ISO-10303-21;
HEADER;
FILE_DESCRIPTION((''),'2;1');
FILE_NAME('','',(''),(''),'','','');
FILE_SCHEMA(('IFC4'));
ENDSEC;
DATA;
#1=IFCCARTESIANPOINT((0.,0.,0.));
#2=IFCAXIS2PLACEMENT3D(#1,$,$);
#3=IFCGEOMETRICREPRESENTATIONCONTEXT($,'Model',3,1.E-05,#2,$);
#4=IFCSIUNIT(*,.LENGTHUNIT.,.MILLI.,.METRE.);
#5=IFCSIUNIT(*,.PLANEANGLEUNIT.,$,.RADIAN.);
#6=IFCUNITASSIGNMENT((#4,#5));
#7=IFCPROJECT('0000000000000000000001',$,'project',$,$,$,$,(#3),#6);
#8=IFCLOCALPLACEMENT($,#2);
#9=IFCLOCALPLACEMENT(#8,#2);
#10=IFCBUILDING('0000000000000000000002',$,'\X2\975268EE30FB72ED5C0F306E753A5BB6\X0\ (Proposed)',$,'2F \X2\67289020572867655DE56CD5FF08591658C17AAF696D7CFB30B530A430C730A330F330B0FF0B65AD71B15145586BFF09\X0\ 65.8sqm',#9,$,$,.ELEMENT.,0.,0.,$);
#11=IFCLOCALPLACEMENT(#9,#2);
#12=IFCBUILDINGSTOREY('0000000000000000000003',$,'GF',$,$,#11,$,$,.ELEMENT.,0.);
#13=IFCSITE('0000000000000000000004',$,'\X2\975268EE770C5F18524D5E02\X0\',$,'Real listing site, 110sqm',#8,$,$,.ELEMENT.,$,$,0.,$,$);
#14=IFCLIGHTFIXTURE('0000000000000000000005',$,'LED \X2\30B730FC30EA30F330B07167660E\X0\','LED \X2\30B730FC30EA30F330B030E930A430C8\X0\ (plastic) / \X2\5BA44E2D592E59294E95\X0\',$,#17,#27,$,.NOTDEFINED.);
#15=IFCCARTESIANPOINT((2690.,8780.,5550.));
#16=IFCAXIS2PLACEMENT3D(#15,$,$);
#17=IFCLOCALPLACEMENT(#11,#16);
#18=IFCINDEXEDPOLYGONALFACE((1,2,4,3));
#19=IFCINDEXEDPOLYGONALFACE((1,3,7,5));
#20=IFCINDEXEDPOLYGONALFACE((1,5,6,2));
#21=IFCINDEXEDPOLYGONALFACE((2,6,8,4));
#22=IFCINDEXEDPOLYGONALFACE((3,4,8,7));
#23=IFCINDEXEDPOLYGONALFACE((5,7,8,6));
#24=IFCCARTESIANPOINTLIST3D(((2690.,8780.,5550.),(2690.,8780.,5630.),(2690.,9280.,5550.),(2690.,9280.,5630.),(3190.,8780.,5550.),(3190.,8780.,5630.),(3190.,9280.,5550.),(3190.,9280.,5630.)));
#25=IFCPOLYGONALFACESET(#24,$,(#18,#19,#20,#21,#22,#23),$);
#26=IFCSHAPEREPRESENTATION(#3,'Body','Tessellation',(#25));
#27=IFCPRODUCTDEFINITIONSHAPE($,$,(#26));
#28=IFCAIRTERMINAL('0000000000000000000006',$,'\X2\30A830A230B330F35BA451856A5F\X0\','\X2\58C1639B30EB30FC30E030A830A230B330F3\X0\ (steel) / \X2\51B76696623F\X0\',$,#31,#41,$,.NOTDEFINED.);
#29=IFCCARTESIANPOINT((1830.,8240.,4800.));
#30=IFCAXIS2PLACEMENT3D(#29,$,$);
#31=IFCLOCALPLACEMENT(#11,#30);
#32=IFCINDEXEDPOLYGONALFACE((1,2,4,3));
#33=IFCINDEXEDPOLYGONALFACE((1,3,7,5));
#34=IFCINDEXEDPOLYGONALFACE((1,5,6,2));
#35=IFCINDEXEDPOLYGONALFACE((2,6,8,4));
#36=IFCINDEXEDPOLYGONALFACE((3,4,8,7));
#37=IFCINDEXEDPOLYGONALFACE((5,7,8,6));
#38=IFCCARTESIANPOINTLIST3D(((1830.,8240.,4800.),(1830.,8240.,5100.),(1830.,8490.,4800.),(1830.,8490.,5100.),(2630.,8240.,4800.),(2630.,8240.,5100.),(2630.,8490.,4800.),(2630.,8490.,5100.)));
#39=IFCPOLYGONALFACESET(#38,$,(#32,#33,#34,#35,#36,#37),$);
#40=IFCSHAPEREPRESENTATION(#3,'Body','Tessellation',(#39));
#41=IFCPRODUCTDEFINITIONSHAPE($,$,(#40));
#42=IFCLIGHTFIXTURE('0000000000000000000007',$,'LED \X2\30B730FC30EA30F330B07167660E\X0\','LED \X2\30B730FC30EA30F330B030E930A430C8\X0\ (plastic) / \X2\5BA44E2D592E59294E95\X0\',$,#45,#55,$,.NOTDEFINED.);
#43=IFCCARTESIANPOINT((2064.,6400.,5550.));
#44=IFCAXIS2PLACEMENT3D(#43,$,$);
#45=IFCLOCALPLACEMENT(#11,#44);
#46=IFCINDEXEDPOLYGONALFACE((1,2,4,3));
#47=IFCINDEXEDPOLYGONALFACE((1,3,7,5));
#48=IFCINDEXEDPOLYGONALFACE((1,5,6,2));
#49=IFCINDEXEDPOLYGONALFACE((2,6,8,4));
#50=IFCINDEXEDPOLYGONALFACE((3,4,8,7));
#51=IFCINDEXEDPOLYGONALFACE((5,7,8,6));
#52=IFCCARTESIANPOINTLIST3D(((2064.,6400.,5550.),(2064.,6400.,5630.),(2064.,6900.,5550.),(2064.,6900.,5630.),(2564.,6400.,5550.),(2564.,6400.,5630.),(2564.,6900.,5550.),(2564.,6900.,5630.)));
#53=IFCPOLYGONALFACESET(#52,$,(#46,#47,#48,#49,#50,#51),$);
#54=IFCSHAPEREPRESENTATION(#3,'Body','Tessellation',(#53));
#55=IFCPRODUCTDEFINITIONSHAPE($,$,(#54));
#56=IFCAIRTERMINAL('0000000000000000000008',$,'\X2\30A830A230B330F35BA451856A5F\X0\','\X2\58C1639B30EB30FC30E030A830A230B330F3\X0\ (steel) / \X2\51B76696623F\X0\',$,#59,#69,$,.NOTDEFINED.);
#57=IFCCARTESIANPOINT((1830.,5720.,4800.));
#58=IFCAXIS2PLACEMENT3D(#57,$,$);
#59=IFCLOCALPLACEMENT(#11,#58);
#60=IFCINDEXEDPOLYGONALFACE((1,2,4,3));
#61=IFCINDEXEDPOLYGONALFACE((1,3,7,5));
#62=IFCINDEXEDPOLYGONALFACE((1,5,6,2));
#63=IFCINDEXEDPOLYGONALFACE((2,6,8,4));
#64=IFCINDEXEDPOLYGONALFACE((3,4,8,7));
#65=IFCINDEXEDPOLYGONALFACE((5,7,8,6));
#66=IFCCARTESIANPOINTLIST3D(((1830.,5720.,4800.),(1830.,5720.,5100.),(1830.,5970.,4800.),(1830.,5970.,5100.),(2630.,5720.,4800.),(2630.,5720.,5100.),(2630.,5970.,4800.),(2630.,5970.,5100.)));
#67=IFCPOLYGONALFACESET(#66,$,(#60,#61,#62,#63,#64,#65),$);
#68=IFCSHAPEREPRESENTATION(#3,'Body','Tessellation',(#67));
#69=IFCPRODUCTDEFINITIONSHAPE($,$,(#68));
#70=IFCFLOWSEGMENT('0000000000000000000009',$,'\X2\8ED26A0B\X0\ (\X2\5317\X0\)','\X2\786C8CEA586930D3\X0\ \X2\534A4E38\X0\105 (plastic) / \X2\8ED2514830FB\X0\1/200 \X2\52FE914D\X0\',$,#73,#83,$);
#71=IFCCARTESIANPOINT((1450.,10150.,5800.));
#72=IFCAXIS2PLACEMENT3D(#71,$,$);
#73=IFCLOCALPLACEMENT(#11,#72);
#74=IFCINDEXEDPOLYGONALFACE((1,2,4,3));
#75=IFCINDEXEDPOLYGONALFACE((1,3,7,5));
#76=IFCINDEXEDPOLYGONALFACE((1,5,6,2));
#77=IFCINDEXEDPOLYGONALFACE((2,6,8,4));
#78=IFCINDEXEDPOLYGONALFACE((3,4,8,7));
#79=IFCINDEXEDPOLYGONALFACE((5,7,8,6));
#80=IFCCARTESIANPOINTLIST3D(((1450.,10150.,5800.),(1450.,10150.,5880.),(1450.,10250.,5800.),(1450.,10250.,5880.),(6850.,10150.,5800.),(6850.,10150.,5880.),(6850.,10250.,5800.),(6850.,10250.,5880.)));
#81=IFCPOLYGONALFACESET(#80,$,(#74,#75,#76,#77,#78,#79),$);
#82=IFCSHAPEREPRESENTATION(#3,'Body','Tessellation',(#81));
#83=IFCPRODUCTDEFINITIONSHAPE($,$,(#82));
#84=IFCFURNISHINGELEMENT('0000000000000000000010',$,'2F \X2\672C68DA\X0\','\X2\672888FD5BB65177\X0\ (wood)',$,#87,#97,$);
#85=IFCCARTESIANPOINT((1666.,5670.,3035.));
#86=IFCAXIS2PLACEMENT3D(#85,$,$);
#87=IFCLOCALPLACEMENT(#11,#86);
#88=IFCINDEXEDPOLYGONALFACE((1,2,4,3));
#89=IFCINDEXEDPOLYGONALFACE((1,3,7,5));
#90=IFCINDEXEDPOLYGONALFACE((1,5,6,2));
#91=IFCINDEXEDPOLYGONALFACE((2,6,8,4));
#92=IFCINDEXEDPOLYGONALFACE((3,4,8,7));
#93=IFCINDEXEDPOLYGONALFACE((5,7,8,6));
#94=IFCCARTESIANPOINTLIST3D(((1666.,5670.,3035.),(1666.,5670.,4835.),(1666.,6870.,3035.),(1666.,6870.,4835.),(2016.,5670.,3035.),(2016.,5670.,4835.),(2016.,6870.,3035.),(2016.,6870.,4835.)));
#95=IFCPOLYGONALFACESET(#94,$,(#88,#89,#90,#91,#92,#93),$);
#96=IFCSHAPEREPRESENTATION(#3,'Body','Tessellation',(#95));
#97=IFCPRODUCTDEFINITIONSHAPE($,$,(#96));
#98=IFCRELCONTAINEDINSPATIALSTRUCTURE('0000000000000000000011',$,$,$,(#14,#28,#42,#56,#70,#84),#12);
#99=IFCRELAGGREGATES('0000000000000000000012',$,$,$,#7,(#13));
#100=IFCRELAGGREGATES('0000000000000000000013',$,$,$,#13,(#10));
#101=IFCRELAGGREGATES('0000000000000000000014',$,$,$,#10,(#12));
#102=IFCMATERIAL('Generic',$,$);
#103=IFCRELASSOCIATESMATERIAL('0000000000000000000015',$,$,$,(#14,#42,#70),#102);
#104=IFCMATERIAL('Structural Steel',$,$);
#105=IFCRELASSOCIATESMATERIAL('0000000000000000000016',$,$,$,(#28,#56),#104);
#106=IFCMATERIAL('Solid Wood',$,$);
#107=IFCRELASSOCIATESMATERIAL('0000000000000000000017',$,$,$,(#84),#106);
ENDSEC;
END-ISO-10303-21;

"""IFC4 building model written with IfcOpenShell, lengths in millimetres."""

from ifc_helpers import new_model, si_unit, frame, frame_2d, origin, place, context, project, spatial, rectangle, extrude, material, element, save


model = new_model("IFC4")

# Units and contexts
model_context = context("Model", 3, precision=1e-05, world=origin())
ifc_project = project(units=[si_unit("LENGTHUNIT", "METRE", prefix="MILLI"), si_unit("PLANEANGLEUNIT", "RADIAN")], contexts=[model_context])

# Site, building, storey
site_placement = place(None, origin())
site = spatial("IfcSite", under=ifc_project, at=site_placement, Name="青森県弘前市", ObjectType="Real listing site, 110sqm", CompositionType="ELEMENT", RefElevation=0.0)
building_placement = place(site_placement, origin())
building = spatial("IfcBuilding", under=site, at=building_placement, Name="青森・狭小の町家 (Proposed)", ObjectType="2F 木造在来工法（外壁窯業系サイディング＋断熱充填） 65.8sqm", CompositionType="ELEMENT", ElevationOfRefHeight=0.0, ElevationOfTerrain=0.0)
storey_placement = place(building_placement, origin())
storey = spatial("IfcBuildingStorey", under=building, at=storey_placement, Name="GF", CompositionType="ELEMENT", Elevation=0.0)

# Shared definitions
ifc_material_1 = material(Name="Solid Wood")

# Shared definitions
ifc_material_2 = material(Name="Structural Steel")

# Shared definitions
ifc_material_3 = material(Name="Generic")

# Light fixture
light_fixture_1_placement = place(storey_placement, frame((2690.0, 8780.0, 5550.0)))
element("IfcLightFixture", 1, at=light_fixture_1_placement, inside=storey, material=ifc_material_3, Name="LED シーリング照明", Description="LED シーリングライト (plastic) / 室中央天井", PredefinedType="NOTDEFINED", context=model_context, shape_type="SweptSolid", body=[
    extrude(rectangle(XDim=500.0, YDim=500.0, at=frame_2d((250.0, 250.0))), frame((2690.0, 8780.0, 5550.0)), (0.0, 0.0, 1.0), 80.0),
])

# Air terminal
air_terminal_1_placement = place(storey_placement, frame((1830.0, 8240.0, 4800.0)))
element("IfcAirTerminal", 2, at=air_terminal_1_placement, inside=storey, material=ifc_material_2, Name="エアコン室内機", Description="壁掛ルームエアコン (steel) / 冷暖房", PredefinedType="NOTDEFINED", context=model_context, shape_type="SweptSolid", body=[
    extrude(rectangle(XDim=800.0, YDim=250.0, at=frame_2d((400.0, 125.0))), frame((1830.0, 8240.0, 4800.0)), (0.0, 0.0, 1.0), 300.0),
])

# Light fixture
light_fixture_2_placement = place(storey_placement, frame((2064.0, 6400.0, 5550.0)))
element("IfcLightFixture", 3, at=light_fixture_2_placement, inside=storey, material=ifc_material_3, Name="LED シーリング照明", Description="LED シーリングライト (plastic) / 室中央天井", PredefinedType="NOTDEFINED", context=model_context, shape_type="SweptSolid", body=[
    extrude(rectangle(XDim=500.0, YDim=500.0, at=frame_2d((250.0, 250.0))), frame((2064.0, 6400.0, 5550.0)), (0.0, 0.0, 1.0), 80.0),
])

# Air terminal
air_terminal_2_placement = place(storey_placement, frame((1830.0, 5720.0, 4800.0)))
element("IfcAirTerminal", 4, at=air_terminal_2_placement, inside=storey, material=ifc_material_2, Name="エアコン室内機", Description="壁掛ルームエアコン (steel) / 冷暖房", PredefinedType="NOTDEFINED", context=model_context, shape_type="SweptSolid", body=[
    extrude(rectangle(XDim=800.0, YDim=250.0, at=frame_2d((400.0, 125.0))), frame((1830.0, 5720.0, 4800.0)), (0.0, 0.0, 1.0), 300.0),
])

# Flow segment
flow_segment_placement = place(storey_placement, frame((1450.0, 10150.0, 5800.0)))
element("IfcFlowSegment", 5, at=flow_segment_placement, inside=storey, material=ifc_material_3, Name="軒樋 (北)", Description="硬質塩ビ 半丸105 (plastic) / 軒先・1/200 勾配", context=model_context, shape_type="SweptSolid", body=[
    extrude(rectangle(XDim=5400.0, YDim=100.0, at=frame_2d((2700.0, 50.0))), frame((1450.0, 10150.0, 5800.0)), (0.0, 0.0, 1.0), 80.0),
])

# Furnishing element
furnishing_placement = place(storey_placement, frame((1666.0, 5670.0, 3035.0)))
element("IfcFurnishingElement", 6, at=furnishing_placement, inside=storey, material=ifc_material_1, Name="2F 本棚", Description="木製家具 (wood)", context=model_context, shape_type="SweptSolid", body=[
    extrude(rectangle(XDim=350.0, YDim=1200.0, at=frame_2d((175.0, 600.0))), frame((1666.0, 5670.0, 3035.0)), (0.0, 0.0, 1.0), 1800.0),
])

save(model, "model.ifc")
